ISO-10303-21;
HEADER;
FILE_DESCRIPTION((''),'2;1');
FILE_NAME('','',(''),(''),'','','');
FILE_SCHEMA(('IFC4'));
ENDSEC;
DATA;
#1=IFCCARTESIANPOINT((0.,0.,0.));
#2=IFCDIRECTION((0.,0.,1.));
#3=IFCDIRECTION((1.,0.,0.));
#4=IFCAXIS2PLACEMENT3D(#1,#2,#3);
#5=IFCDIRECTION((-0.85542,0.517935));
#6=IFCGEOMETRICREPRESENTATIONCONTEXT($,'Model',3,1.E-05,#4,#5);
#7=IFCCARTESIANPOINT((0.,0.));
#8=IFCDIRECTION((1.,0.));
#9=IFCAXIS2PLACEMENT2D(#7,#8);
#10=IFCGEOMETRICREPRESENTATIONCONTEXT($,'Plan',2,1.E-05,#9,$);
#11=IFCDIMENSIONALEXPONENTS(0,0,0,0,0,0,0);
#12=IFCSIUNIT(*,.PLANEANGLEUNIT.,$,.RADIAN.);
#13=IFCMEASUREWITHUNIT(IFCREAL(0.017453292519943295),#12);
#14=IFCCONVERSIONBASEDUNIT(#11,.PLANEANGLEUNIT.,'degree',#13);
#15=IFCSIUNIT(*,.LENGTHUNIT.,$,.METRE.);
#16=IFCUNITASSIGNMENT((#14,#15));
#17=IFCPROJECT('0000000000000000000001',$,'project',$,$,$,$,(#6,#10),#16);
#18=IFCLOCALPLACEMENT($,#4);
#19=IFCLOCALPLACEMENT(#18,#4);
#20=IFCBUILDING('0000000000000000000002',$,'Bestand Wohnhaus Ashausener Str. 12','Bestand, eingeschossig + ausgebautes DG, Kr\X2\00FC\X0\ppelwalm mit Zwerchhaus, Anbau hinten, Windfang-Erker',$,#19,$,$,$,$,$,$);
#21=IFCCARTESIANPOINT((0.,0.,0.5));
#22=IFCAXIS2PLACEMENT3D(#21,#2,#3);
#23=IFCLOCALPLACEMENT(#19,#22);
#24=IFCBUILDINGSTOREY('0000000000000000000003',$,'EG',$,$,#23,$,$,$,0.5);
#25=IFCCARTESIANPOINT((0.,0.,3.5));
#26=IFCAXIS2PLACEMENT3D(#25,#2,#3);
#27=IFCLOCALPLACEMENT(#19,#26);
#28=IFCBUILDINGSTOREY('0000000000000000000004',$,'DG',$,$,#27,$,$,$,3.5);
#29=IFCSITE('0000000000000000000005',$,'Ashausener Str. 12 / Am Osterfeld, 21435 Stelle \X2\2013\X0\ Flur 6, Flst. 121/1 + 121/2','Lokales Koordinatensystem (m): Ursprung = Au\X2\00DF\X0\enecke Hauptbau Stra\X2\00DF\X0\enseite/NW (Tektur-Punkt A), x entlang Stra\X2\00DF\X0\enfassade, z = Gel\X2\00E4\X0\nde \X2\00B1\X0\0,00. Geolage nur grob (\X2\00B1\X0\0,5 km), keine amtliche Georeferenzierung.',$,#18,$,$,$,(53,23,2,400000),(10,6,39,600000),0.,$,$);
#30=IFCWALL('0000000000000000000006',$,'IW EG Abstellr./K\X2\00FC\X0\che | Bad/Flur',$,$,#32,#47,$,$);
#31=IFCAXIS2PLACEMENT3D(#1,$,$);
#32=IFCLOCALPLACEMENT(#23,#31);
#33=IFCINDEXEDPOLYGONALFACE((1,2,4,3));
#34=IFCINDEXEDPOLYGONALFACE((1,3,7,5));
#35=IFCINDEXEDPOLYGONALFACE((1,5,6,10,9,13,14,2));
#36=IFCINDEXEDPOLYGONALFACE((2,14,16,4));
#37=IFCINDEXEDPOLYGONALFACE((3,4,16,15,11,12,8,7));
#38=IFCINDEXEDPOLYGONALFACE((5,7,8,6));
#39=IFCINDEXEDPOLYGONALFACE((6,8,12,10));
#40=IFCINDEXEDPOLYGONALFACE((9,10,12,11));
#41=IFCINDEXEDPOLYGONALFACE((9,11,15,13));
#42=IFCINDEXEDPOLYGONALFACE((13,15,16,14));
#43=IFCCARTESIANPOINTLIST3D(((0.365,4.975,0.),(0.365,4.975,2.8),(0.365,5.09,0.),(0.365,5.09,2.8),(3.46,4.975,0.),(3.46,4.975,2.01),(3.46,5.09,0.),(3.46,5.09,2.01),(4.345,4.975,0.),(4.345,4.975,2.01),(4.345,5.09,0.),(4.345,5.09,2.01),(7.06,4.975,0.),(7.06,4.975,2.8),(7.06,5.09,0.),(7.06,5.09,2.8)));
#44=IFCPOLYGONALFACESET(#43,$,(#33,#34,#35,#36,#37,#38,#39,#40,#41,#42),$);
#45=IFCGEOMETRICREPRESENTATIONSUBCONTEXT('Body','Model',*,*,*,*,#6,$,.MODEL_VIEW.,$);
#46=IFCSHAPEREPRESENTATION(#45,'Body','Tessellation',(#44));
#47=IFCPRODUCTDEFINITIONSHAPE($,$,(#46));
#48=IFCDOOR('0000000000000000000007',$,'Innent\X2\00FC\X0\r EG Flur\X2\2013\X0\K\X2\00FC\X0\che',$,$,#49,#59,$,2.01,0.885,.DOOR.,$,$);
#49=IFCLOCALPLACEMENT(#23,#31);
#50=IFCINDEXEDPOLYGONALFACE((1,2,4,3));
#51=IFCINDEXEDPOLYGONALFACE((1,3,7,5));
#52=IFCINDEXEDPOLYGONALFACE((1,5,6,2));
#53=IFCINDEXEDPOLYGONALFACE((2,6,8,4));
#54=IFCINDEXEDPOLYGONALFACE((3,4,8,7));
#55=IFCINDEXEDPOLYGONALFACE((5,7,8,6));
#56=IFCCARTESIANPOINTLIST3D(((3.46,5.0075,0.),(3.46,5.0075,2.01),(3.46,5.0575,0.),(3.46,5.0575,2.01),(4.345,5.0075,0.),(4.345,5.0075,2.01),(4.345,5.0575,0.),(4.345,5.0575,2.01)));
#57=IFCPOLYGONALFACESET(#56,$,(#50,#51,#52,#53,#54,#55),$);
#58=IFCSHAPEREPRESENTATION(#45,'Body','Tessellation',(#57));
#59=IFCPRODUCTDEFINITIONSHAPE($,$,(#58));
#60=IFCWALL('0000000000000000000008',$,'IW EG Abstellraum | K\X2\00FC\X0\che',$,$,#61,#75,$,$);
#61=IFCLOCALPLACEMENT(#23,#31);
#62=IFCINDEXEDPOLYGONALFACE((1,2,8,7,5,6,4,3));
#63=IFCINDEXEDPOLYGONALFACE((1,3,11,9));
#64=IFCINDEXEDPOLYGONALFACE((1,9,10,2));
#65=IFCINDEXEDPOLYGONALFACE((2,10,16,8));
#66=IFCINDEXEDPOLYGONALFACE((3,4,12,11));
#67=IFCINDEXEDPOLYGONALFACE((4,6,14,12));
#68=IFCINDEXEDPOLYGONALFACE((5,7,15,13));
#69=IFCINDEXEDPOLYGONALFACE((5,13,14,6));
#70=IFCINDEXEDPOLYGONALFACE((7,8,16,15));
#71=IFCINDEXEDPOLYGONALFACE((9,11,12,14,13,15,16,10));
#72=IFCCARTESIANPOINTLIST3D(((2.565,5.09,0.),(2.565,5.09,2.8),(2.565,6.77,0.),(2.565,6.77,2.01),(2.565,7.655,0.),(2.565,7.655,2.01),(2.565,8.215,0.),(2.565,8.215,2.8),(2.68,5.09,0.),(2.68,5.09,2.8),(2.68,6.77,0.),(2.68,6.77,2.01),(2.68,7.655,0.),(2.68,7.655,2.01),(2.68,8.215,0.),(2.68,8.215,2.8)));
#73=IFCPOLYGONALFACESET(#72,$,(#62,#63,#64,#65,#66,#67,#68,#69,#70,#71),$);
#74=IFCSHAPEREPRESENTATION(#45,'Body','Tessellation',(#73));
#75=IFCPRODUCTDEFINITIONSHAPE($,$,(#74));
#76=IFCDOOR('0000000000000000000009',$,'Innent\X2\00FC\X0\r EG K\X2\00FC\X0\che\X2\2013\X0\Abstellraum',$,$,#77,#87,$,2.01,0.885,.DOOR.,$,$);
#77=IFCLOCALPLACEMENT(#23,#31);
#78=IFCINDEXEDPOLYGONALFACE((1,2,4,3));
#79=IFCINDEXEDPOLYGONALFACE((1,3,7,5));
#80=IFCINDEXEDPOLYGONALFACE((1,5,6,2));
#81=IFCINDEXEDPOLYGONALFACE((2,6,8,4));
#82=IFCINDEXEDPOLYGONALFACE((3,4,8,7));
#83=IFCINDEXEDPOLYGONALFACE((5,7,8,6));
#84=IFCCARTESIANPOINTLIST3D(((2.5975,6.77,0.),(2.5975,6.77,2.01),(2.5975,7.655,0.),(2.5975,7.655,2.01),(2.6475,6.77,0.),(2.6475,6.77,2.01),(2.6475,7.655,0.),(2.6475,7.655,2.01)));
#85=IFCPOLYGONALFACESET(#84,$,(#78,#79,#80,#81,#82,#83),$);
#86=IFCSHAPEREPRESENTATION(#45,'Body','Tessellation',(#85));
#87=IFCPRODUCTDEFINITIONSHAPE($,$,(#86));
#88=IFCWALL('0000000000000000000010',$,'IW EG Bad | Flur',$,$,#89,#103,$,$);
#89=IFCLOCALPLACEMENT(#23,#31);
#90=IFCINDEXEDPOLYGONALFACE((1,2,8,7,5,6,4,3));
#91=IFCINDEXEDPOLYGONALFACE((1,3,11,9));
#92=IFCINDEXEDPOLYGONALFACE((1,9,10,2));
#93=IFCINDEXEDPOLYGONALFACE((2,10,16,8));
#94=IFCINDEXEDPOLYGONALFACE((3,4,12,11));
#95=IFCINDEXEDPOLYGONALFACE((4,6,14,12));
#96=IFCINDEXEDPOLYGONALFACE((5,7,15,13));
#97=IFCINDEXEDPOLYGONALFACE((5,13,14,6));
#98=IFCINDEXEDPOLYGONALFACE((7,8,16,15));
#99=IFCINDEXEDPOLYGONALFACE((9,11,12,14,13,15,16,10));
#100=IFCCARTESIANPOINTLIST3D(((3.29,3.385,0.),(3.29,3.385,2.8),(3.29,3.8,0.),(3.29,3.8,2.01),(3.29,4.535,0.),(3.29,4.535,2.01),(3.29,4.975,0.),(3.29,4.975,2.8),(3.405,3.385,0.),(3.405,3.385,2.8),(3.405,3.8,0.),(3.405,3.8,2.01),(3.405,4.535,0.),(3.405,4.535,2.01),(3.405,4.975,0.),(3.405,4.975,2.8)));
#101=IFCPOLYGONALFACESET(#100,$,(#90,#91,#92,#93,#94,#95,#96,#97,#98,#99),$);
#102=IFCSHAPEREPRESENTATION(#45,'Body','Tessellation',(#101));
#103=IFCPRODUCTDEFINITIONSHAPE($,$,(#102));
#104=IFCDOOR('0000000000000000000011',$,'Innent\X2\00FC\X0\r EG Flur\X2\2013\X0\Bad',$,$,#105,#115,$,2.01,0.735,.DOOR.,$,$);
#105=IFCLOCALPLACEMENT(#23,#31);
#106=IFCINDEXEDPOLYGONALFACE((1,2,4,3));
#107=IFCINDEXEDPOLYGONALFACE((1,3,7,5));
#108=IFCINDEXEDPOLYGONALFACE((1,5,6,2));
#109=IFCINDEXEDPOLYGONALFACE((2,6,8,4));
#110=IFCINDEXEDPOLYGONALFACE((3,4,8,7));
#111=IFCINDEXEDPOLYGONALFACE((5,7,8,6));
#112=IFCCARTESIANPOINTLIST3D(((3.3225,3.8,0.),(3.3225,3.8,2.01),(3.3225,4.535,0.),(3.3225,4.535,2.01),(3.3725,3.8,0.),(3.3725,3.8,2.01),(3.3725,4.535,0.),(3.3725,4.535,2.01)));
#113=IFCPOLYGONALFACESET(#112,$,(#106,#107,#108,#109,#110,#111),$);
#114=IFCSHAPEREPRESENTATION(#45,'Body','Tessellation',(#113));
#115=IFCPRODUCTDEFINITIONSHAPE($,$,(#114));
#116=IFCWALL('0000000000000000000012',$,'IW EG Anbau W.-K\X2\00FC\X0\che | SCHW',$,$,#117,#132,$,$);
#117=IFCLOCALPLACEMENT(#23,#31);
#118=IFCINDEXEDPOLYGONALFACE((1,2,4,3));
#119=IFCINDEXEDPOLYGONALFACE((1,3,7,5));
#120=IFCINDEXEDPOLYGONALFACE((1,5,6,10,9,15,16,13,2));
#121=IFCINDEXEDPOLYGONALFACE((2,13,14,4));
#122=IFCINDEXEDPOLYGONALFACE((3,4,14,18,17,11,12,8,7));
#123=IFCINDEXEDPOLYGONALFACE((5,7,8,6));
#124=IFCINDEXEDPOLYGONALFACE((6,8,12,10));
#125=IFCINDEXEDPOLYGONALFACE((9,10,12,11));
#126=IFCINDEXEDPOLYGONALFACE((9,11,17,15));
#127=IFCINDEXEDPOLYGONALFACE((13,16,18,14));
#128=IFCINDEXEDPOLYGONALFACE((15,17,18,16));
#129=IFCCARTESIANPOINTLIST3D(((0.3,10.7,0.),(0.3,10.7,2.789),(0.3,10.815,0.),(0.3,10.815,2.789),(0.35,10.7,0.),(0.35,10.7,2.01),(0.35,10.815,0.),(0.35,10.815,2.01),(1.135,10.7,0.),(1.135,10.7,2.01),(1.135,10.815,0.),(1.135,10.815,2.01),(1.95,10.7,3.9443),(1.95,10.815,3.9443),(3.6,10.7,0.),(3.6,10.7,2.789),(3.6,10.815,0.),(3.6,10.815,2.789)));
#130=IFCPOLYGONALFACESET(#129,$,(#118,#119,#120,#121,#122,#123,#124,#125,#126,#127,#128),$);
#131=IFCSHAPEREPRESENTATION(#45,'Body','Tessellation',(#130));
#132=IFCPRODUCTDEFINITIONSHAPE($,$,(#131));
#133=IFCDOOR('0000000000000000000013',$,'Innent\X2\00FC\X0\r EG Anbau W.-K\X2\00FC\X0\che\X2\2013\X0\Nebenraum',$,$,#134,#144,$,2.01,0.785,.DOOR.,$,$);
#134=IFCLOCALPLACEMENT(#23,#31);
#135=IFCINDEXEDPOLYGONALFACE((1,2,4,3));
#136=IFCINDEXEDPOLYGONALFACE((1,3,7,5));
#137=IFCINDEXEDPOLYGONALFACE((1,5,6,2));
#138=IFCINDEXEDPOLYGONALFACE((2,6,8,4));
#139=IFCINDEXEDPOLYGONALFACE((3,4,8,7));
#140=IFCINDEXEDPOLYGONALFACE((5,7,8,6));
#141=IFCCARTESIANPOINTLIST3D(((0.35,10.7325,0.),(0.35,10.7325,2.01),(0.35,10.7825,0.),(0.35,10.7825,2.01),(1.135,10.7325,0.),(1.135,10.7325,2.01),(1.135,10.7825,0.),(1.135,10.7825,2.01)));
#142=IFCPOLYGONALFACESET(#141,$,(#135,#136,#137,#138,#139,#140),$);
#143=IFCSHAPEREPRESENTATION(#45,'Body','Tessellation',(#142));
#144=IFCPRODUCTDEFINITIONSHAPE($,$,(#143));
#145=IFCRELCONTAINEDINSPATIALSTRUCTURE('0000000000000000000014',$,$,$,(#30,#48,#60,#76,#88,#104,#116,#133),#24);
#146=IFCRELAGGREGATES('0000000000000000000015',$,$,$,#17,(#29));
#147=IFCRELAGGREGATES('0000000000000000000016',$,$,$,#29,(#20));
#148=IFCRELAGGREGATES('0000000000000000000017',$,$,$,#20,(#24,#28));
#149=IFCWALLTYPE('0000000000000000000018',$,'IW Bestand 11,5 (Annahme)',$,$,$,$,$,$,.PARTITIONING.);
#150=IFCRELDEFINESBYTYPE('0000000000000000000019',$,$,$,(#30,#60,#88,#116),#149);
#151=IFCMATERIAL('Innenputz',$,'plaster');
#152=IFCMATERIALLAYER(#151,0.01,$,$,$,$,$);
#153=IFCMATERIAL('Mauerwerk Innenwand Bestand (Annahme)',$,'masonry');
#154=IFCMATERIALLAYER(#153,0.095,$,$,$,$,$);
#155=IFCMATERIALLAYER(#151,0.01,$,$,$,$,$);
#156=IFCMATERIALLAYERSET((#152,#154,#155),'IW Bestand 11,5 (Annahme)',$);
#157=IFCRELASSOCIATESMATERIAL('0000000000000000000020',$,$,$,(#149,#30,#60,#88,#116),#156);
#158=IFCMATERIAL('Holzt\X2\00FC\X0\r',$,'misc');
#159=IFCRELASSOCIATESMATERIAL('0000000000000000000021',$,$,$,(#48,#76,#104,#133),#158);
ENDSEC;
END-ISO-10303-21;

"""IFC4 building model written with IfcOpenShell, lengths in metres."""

from ifc_helpers import new_model, entity, si_unit, converted_unit, direction, frame, origin_with_axes, origin_2d_with_axis, place, context, subcontext, project, spatial, indexed_curve, outline, extrude, clip, halfspace, material, layer, layer_set, layer_usage, type_object, element, fill, save


model = new_model("IFC4")

# Units and contexts
model_context = context("Model", 3, precision=1e-05, world=origin_with_axes(), true_north=direction((-0.85542, 0.517935)))
plan_context = context("Plan", 2, precision=1e-05, world=origin_2d_with_axis())
body_context = subcontext(model_context, "Body", "Model", "MODEL_VIEW")
ifc_project = project(units=[converted_unit("PLANEANGLEUNIT", "degree", entity("IfcReal", 0.017453292519943295), si_unit("PLANEANGLEUNIT", "RADIAN"), dimensions=[0, 0, 0, 0, 0, 0, 0]), si_unit("LENGTHUNIT", "METRE")], contexts=[model_context, plan_context])

# Site, building, storey
site_placement = place(None, origin_with_axes())
site = spatial("IfcSite", under=ifc_project, at=site_placement, Name="Ashausener Str. 12 / Am Osterfeld, 21435 Stelle – Flur 6, Flst. 121/1 + 121/2", Description="Lokales Koordinatensystem (m): Ursprung = Außenecke Hauptbau Straßenseite/NW (Tektur-Punkt A), x entlang Straßenfassade, z = Gelände ±0,00. Geolage nur grob (±0,5 km), keine amtliche Georeferenzierung.", RefLatitude=(53, 23, 2, 400000), RefLongitude=(10, 6, 39, 600000), RefElevation=0.0)
building_placement = place(site_placement, origin_with_axes())
building = spatial("IfcBuilding", under=site, at=building_placement, Name="Bestand Wohnhaus Ashausener Str. 12", Description="Bestand, eingeschossig + ausgebautes DG, Krüppelwalm mit Zwerchhaus, Anbau hinten, Windfang-Erker")
storey_1_placement = place(building_placement, frame((0.0, 0.0, 0.5), z_axis=(0.0, 0.0, 1.0), x_axis=(1.0, 0.0, 0.0)))
storey_1 = spatial("IfcBuildingStorey", under=building, at=storey_1_placement, Name="EG", Elevation=0.5)

# Shared definitions
storey_2_placement = place(building_placement, frame((0.0, 0.0, 3.5), z_axis=(0.0, 0.0, 1.0), x_axis=(1.0, 0.0, 0.0)))
storey_2 = spatial("IfcBuildingStorey", under=building, at=storey_2_placement, Name="DG", Elevation=3.5)

# Walls, openings, doors
ifc_material_1 = material(Name="Innenputz", Category="plaster")
ifc_layer_1 = layer(ifc_material_1, 0.01)
ifc_material_2 = material(Name="Mauerwerk Innenwand Bestand (Annahme)", Category="masonry")
ifc_layer_2 = layer(ifc_material_2, 0.095)
ifc_layer_3 = layer(ifc_material_1, 0.01)
ifc_layer_set_1 = layer_set([ifc_layer_1, ifc_layer_2, ifc_layer_3], Name="IW Bestand 11,5 (Annahme)")
ifc_layer_usage_1 = layer_usage(ifc_layer_set_1, "AXIS2", "POSITIVE", 0.0)
wall_type_1 = type_object("IfcWallType", Name="IW Bestand 11,5 (Annahme)", PredefinedType="PARTITIONING", material=ifc_layer_set_1)
wall_1_placement = place(storey_1_placement, frame((0.365, 4.975, 0.0), z_axis=(0.0, 0.0, 1.0), x_axis=(1.0, 0.0, 0.0)))
wall_1 = element("IfcWall", 1, at=wall_1_placement, inside=storey_1, type_object=wall_type_1, material=ifc_layer_usage_1, Name="IW EG Abstellr./Küche | Bad/Flur", context=body_context, shape_type="SweptSolid", body=[
    extrude(outline(indexed_curve([(0.0, 0.0), (0.0, 0.115), (6.695, 0.115), (6.695, 0.0), (0.0, 0.0)], self_intersect=False)), origin_with_axes(), (0.0, 0.0, 1.0), 2.8),
])
opening_1_placement = place(wall_1_placement, frame((3.095, -0.1, 0.0), z_axis=(0.0, 0.0, 1.0), x_axis=(1.0, 0.0, 0.0)))
opening_1 = element("IfcOpeningElement", 2, at=opening_1_placement, cuts=wall_1, context=body_context, shape_type="SweptSolid", body=[
    extrude(outline(indexed_curve([(0.0, 0.0), (0.0, 0.315), (0.885, 0.315), (0.885, 0.0), (0.0, 0.0)], self_intersect=False)), origin_with_axes(), (0.0, 0.0, 1.0), 2.01),
])
ifc_material_3 = material(Name="Holztür", Category="misc")
door_1_placement = place(storey_1_placement, frame((3.46, 5.0075, 0.0), z_axis=(0.0, 0.0, 1.0), x_axis=(1.0, 0.0, 0.0)))
door_1 = element("IfcDoor", 3, at=door_1_placement, inside=storey_1, material=ifc_material_3, Name="Innentür EG Flur–Küche", OverallHeight=2.01, OverallWidth=0.885, PredefinedType="DOOR", context=body_context, shape_type="SweptSolid", body=[
    extrude(outline(indexed_curve([(0.0, 0.0), (0.0, 0.05), (0.885, 0.05), (0.885, 0.0), (0.0, 0.0)], self_intersect=False)), origin_with_axes(), (0.0, 0.0, 1.0), 2.01),
])
fill(opening_1, door_1)
ifc_layer_usage_2 = layer_usage(ifc_layer_set_1, "AXIS2", "POSITIVE", 0.0)
wall_2_placement = place(storey_1_placement, frame((2.565, 8.215, 0.0), z_axis=(0.0, 0.0, 1.0), x_axis=(0.0, -1.0, 0.0)))
wall_2 = element("IfcWall", 4, at=wall_2_placement, inside=storey_1, type_object=wall_type_1, material=ifc_layer_usage_2, Name="IW EG Abstellraum | Küche", context=body_context, shape_type="SweptSolid", body=[
    extrude(outline(indexed_curve([(0.0, 0.0), (0.0, 0.115), (3.125, 0.115), (3.125, 0.0), (0.0, 0.0)], self_intersect=False)), origin_with_axes(), (0.0, 0.0, 1.0), 2.8),
])
opening_2_placement = place(wall_2_placement, frame((0.56, -0.1, 0.0), z_axis=(0.0, 0.0, 1.0), x_axis=(1.0, 0.0, 0.0)))
opening_2 = element("IfcOpeningElement", 5, at=opening_2_placement, cuts=wall_2, context=body_context, shape_type="SweptSolid", body=[
    extrude(outline(indexed_curve([(0.0, 0.0), (0.0, 0.315), (0.885, 0.315), (0.885, 0.0), (0.0, 0.0)], self_intersect=False)), origin_with_axes(), (0.0, 0.0, 1.0), 2.01),
])
door_2_placement = place(storey_1_placement, frame((2.5975, 7.655, 0.0), z_axis=(0.0, 0.0, 1.0), x_axis=(0.0, -1.0, 0.0)))
door_2 = element("IfcDoor", 6, at=door_2_placement, inside=storey_1, material=ifc_material_3, Name="Innentür EG Küche–Abstellraum", OverallHeight=2.01, OverallWidth=0.885, PredefinedType="DOOR", context=body_context, shape_type="SweptSolid", body=[
    extrude(outline(indexed_curve([(0.0, 0.0), (0.0, 0.05), (0.885, 0.05), (0.885, 0.0), (0.0, 0.0)], self_intersect=False)), origin_with_axes(), (0.0, 0.0, 1.0), 2.01),
])
fill(opening_2, door_2)
ifc_layer_usage_3 = layer_usage(ifc_layer_set_1, "AXIS2", "POSITIVE", 0.0)
wall_3_placement = place(storey_1_placement, frame((3.29, 4.975, 0.0), z_axis=(0.0, 0.0, 1.0), x_axis=(0.0, -1.0, 0.0)))
wall_3 = element("IfcWall", 7, at=wall_3_placement, inside=storey_1, type_object=wall_type_1, material=ifc_layer_usage_3, Name="IW EG Bad | Flur", context=body_context, shape_type="SweptSolid", body=[
    extrude(outline(indexed_curve([(0.0, 0.0), (0.0, 0.115), (1.59, 0.115), (1.59, 0.0), (0.0, 0.0)], self_intersect=False)), origin_with_axes(), (0.0, 0.0, 1.0), 2.8),
])
opening_3_placement = place(wall_3_placement, frame((0.44, -0.1, 0.0), z_axis=(0.0, 0.0, 1.0), x_axis=(1.0, 0.0, 0.0)))
opening_3 = element("IfcOpeningElement", 8, at=opening_3_placement, cuts=wall_3, context=body_context, shape_type="SweptSolid", body=[
    extrude(outline(indexed_curve([(0.0, 0.0), (0.0, 0.315), (0.735, 0.315), (0.735, 0.0), (0.0, 0.0)], self_intersect=False)), origin_with_axes(), (0.0, 0.0, 1.0), 2.01),
])
door_3_placement = place(storey_1_placement, frame((3.3225, 4.535, 0.0), z_axis=(0.0, 0.0, 1.0), x_axis=(0.0, -1.0, 0.0)))
door_3 = element("IfcDoor", 9, at=door_3_placement, inside=storey_1, material=ifc_material_3, Name="Innentür EG Flur–Bad", OverallHeight=2.01, OverallWidth=0.735, PredefinedType="DOOR", context=body_context, shape_type="SweptSolid", body=[
    extrude(outline(indexed_curve([(0.0, 0.0), (0.0, 0.05), (0.735, 0.05), (0.735, 0.0), (0.0, 0.0)], self_intersect=False)), origin_with_axes(), (0.0, 0.0, 1.0), 2.01),
])
fill(opening_3, door_3)
ifc_layer_usage_4 = layer_usage(ifc_layer_set_1, "AXIS2", "POSITIVE", 0.0)
wall_4_placement = place(storey_1_placement, frame((0.3, 10.7, 0.0), z_axis=(0.0, 0.0, 1.0), x_axis=(1.0, 0.0, 0.0)))
wall_4 = element("IfcWall", 10, at=wall_4_placement, inside=storey_1, type_object=wall_type_1, material=ifc_layer_usage_4, Name="IW EG Anbau W.-Küche | SCHW", context=body_context, shape_type="Clipping", body=[
    clip(clip(extrude(outline(indexed_curve([(0.0, 0.0), (0.0, 0.115), (3.3, 0.115), (3.3, 0.0), (0.0, 0.0)], self_intersect=False)), origin_with_axes(), (0.0, 0.0, 1.0), 8.0), halfspace(frame((3.8753, -10.7, 2.3862), z_axis=(0.57358, 0.0, 0.81915), x_axis=(0.0, -1.0, 0.0)), False)), halfspace(frame((-0.5753, -10.7, 2.3862), z_axis=(-0.57358, 0.0, 0.81915), x_axis=(0.0, 1.0, 0.0)), False)),
])
opening_4_placement = place(wall_4_placement, frame((0.05, -0.1, 0.0), z_axis=(0.0, 0.0, 1.0), x_axis=(1.0, 0.0, 0.0)))
opening_4 = element("IfcOpeningElement", 11, at=opening_4_placement, cuts=wall_4, context=body_context, shape_type="SweptSolid", body=[
    extrude(outline(indexed_curve([(0.0, 0.0), (0.0, 0.315), (0.785, 0.315), (0.785, 0.0), (0.0, 0.0)], self_intersect=False)), origin_with_axes(), (0.0, 0.0, 1.0), 2.01),
])
door_4_placement = place(storey_1_placement, frame((0.35, 10.7325, 0.0), z_axis=(0.0, 0.0, 1.0), x_axis=(1.0, 0.0, 0.0)))
door_4 = element("IfcDoor", 12, at=door_4_placement, inside=storey_1, material=ifc_material_3, Name="Innentür EG Anbau W.-Küche–Nebenraum", OverallHeight=2.01, OverallWidth=0.785, PredefinedType="DOOR", context=body_context, shape_type="SweptSolid", body=[
    extrude(outline(indexed_curve([(0.0, 0.0), (0.0, 0.05), (0.785, 0.05), (0.785, 0.0), (0.0, 0.0)], self_intersect=False)), origin_with_axes(), (0.0, 0.0, 1.0), 2.01),
])
fill(opening_4, door_4)

save(model, "model.ifc")
